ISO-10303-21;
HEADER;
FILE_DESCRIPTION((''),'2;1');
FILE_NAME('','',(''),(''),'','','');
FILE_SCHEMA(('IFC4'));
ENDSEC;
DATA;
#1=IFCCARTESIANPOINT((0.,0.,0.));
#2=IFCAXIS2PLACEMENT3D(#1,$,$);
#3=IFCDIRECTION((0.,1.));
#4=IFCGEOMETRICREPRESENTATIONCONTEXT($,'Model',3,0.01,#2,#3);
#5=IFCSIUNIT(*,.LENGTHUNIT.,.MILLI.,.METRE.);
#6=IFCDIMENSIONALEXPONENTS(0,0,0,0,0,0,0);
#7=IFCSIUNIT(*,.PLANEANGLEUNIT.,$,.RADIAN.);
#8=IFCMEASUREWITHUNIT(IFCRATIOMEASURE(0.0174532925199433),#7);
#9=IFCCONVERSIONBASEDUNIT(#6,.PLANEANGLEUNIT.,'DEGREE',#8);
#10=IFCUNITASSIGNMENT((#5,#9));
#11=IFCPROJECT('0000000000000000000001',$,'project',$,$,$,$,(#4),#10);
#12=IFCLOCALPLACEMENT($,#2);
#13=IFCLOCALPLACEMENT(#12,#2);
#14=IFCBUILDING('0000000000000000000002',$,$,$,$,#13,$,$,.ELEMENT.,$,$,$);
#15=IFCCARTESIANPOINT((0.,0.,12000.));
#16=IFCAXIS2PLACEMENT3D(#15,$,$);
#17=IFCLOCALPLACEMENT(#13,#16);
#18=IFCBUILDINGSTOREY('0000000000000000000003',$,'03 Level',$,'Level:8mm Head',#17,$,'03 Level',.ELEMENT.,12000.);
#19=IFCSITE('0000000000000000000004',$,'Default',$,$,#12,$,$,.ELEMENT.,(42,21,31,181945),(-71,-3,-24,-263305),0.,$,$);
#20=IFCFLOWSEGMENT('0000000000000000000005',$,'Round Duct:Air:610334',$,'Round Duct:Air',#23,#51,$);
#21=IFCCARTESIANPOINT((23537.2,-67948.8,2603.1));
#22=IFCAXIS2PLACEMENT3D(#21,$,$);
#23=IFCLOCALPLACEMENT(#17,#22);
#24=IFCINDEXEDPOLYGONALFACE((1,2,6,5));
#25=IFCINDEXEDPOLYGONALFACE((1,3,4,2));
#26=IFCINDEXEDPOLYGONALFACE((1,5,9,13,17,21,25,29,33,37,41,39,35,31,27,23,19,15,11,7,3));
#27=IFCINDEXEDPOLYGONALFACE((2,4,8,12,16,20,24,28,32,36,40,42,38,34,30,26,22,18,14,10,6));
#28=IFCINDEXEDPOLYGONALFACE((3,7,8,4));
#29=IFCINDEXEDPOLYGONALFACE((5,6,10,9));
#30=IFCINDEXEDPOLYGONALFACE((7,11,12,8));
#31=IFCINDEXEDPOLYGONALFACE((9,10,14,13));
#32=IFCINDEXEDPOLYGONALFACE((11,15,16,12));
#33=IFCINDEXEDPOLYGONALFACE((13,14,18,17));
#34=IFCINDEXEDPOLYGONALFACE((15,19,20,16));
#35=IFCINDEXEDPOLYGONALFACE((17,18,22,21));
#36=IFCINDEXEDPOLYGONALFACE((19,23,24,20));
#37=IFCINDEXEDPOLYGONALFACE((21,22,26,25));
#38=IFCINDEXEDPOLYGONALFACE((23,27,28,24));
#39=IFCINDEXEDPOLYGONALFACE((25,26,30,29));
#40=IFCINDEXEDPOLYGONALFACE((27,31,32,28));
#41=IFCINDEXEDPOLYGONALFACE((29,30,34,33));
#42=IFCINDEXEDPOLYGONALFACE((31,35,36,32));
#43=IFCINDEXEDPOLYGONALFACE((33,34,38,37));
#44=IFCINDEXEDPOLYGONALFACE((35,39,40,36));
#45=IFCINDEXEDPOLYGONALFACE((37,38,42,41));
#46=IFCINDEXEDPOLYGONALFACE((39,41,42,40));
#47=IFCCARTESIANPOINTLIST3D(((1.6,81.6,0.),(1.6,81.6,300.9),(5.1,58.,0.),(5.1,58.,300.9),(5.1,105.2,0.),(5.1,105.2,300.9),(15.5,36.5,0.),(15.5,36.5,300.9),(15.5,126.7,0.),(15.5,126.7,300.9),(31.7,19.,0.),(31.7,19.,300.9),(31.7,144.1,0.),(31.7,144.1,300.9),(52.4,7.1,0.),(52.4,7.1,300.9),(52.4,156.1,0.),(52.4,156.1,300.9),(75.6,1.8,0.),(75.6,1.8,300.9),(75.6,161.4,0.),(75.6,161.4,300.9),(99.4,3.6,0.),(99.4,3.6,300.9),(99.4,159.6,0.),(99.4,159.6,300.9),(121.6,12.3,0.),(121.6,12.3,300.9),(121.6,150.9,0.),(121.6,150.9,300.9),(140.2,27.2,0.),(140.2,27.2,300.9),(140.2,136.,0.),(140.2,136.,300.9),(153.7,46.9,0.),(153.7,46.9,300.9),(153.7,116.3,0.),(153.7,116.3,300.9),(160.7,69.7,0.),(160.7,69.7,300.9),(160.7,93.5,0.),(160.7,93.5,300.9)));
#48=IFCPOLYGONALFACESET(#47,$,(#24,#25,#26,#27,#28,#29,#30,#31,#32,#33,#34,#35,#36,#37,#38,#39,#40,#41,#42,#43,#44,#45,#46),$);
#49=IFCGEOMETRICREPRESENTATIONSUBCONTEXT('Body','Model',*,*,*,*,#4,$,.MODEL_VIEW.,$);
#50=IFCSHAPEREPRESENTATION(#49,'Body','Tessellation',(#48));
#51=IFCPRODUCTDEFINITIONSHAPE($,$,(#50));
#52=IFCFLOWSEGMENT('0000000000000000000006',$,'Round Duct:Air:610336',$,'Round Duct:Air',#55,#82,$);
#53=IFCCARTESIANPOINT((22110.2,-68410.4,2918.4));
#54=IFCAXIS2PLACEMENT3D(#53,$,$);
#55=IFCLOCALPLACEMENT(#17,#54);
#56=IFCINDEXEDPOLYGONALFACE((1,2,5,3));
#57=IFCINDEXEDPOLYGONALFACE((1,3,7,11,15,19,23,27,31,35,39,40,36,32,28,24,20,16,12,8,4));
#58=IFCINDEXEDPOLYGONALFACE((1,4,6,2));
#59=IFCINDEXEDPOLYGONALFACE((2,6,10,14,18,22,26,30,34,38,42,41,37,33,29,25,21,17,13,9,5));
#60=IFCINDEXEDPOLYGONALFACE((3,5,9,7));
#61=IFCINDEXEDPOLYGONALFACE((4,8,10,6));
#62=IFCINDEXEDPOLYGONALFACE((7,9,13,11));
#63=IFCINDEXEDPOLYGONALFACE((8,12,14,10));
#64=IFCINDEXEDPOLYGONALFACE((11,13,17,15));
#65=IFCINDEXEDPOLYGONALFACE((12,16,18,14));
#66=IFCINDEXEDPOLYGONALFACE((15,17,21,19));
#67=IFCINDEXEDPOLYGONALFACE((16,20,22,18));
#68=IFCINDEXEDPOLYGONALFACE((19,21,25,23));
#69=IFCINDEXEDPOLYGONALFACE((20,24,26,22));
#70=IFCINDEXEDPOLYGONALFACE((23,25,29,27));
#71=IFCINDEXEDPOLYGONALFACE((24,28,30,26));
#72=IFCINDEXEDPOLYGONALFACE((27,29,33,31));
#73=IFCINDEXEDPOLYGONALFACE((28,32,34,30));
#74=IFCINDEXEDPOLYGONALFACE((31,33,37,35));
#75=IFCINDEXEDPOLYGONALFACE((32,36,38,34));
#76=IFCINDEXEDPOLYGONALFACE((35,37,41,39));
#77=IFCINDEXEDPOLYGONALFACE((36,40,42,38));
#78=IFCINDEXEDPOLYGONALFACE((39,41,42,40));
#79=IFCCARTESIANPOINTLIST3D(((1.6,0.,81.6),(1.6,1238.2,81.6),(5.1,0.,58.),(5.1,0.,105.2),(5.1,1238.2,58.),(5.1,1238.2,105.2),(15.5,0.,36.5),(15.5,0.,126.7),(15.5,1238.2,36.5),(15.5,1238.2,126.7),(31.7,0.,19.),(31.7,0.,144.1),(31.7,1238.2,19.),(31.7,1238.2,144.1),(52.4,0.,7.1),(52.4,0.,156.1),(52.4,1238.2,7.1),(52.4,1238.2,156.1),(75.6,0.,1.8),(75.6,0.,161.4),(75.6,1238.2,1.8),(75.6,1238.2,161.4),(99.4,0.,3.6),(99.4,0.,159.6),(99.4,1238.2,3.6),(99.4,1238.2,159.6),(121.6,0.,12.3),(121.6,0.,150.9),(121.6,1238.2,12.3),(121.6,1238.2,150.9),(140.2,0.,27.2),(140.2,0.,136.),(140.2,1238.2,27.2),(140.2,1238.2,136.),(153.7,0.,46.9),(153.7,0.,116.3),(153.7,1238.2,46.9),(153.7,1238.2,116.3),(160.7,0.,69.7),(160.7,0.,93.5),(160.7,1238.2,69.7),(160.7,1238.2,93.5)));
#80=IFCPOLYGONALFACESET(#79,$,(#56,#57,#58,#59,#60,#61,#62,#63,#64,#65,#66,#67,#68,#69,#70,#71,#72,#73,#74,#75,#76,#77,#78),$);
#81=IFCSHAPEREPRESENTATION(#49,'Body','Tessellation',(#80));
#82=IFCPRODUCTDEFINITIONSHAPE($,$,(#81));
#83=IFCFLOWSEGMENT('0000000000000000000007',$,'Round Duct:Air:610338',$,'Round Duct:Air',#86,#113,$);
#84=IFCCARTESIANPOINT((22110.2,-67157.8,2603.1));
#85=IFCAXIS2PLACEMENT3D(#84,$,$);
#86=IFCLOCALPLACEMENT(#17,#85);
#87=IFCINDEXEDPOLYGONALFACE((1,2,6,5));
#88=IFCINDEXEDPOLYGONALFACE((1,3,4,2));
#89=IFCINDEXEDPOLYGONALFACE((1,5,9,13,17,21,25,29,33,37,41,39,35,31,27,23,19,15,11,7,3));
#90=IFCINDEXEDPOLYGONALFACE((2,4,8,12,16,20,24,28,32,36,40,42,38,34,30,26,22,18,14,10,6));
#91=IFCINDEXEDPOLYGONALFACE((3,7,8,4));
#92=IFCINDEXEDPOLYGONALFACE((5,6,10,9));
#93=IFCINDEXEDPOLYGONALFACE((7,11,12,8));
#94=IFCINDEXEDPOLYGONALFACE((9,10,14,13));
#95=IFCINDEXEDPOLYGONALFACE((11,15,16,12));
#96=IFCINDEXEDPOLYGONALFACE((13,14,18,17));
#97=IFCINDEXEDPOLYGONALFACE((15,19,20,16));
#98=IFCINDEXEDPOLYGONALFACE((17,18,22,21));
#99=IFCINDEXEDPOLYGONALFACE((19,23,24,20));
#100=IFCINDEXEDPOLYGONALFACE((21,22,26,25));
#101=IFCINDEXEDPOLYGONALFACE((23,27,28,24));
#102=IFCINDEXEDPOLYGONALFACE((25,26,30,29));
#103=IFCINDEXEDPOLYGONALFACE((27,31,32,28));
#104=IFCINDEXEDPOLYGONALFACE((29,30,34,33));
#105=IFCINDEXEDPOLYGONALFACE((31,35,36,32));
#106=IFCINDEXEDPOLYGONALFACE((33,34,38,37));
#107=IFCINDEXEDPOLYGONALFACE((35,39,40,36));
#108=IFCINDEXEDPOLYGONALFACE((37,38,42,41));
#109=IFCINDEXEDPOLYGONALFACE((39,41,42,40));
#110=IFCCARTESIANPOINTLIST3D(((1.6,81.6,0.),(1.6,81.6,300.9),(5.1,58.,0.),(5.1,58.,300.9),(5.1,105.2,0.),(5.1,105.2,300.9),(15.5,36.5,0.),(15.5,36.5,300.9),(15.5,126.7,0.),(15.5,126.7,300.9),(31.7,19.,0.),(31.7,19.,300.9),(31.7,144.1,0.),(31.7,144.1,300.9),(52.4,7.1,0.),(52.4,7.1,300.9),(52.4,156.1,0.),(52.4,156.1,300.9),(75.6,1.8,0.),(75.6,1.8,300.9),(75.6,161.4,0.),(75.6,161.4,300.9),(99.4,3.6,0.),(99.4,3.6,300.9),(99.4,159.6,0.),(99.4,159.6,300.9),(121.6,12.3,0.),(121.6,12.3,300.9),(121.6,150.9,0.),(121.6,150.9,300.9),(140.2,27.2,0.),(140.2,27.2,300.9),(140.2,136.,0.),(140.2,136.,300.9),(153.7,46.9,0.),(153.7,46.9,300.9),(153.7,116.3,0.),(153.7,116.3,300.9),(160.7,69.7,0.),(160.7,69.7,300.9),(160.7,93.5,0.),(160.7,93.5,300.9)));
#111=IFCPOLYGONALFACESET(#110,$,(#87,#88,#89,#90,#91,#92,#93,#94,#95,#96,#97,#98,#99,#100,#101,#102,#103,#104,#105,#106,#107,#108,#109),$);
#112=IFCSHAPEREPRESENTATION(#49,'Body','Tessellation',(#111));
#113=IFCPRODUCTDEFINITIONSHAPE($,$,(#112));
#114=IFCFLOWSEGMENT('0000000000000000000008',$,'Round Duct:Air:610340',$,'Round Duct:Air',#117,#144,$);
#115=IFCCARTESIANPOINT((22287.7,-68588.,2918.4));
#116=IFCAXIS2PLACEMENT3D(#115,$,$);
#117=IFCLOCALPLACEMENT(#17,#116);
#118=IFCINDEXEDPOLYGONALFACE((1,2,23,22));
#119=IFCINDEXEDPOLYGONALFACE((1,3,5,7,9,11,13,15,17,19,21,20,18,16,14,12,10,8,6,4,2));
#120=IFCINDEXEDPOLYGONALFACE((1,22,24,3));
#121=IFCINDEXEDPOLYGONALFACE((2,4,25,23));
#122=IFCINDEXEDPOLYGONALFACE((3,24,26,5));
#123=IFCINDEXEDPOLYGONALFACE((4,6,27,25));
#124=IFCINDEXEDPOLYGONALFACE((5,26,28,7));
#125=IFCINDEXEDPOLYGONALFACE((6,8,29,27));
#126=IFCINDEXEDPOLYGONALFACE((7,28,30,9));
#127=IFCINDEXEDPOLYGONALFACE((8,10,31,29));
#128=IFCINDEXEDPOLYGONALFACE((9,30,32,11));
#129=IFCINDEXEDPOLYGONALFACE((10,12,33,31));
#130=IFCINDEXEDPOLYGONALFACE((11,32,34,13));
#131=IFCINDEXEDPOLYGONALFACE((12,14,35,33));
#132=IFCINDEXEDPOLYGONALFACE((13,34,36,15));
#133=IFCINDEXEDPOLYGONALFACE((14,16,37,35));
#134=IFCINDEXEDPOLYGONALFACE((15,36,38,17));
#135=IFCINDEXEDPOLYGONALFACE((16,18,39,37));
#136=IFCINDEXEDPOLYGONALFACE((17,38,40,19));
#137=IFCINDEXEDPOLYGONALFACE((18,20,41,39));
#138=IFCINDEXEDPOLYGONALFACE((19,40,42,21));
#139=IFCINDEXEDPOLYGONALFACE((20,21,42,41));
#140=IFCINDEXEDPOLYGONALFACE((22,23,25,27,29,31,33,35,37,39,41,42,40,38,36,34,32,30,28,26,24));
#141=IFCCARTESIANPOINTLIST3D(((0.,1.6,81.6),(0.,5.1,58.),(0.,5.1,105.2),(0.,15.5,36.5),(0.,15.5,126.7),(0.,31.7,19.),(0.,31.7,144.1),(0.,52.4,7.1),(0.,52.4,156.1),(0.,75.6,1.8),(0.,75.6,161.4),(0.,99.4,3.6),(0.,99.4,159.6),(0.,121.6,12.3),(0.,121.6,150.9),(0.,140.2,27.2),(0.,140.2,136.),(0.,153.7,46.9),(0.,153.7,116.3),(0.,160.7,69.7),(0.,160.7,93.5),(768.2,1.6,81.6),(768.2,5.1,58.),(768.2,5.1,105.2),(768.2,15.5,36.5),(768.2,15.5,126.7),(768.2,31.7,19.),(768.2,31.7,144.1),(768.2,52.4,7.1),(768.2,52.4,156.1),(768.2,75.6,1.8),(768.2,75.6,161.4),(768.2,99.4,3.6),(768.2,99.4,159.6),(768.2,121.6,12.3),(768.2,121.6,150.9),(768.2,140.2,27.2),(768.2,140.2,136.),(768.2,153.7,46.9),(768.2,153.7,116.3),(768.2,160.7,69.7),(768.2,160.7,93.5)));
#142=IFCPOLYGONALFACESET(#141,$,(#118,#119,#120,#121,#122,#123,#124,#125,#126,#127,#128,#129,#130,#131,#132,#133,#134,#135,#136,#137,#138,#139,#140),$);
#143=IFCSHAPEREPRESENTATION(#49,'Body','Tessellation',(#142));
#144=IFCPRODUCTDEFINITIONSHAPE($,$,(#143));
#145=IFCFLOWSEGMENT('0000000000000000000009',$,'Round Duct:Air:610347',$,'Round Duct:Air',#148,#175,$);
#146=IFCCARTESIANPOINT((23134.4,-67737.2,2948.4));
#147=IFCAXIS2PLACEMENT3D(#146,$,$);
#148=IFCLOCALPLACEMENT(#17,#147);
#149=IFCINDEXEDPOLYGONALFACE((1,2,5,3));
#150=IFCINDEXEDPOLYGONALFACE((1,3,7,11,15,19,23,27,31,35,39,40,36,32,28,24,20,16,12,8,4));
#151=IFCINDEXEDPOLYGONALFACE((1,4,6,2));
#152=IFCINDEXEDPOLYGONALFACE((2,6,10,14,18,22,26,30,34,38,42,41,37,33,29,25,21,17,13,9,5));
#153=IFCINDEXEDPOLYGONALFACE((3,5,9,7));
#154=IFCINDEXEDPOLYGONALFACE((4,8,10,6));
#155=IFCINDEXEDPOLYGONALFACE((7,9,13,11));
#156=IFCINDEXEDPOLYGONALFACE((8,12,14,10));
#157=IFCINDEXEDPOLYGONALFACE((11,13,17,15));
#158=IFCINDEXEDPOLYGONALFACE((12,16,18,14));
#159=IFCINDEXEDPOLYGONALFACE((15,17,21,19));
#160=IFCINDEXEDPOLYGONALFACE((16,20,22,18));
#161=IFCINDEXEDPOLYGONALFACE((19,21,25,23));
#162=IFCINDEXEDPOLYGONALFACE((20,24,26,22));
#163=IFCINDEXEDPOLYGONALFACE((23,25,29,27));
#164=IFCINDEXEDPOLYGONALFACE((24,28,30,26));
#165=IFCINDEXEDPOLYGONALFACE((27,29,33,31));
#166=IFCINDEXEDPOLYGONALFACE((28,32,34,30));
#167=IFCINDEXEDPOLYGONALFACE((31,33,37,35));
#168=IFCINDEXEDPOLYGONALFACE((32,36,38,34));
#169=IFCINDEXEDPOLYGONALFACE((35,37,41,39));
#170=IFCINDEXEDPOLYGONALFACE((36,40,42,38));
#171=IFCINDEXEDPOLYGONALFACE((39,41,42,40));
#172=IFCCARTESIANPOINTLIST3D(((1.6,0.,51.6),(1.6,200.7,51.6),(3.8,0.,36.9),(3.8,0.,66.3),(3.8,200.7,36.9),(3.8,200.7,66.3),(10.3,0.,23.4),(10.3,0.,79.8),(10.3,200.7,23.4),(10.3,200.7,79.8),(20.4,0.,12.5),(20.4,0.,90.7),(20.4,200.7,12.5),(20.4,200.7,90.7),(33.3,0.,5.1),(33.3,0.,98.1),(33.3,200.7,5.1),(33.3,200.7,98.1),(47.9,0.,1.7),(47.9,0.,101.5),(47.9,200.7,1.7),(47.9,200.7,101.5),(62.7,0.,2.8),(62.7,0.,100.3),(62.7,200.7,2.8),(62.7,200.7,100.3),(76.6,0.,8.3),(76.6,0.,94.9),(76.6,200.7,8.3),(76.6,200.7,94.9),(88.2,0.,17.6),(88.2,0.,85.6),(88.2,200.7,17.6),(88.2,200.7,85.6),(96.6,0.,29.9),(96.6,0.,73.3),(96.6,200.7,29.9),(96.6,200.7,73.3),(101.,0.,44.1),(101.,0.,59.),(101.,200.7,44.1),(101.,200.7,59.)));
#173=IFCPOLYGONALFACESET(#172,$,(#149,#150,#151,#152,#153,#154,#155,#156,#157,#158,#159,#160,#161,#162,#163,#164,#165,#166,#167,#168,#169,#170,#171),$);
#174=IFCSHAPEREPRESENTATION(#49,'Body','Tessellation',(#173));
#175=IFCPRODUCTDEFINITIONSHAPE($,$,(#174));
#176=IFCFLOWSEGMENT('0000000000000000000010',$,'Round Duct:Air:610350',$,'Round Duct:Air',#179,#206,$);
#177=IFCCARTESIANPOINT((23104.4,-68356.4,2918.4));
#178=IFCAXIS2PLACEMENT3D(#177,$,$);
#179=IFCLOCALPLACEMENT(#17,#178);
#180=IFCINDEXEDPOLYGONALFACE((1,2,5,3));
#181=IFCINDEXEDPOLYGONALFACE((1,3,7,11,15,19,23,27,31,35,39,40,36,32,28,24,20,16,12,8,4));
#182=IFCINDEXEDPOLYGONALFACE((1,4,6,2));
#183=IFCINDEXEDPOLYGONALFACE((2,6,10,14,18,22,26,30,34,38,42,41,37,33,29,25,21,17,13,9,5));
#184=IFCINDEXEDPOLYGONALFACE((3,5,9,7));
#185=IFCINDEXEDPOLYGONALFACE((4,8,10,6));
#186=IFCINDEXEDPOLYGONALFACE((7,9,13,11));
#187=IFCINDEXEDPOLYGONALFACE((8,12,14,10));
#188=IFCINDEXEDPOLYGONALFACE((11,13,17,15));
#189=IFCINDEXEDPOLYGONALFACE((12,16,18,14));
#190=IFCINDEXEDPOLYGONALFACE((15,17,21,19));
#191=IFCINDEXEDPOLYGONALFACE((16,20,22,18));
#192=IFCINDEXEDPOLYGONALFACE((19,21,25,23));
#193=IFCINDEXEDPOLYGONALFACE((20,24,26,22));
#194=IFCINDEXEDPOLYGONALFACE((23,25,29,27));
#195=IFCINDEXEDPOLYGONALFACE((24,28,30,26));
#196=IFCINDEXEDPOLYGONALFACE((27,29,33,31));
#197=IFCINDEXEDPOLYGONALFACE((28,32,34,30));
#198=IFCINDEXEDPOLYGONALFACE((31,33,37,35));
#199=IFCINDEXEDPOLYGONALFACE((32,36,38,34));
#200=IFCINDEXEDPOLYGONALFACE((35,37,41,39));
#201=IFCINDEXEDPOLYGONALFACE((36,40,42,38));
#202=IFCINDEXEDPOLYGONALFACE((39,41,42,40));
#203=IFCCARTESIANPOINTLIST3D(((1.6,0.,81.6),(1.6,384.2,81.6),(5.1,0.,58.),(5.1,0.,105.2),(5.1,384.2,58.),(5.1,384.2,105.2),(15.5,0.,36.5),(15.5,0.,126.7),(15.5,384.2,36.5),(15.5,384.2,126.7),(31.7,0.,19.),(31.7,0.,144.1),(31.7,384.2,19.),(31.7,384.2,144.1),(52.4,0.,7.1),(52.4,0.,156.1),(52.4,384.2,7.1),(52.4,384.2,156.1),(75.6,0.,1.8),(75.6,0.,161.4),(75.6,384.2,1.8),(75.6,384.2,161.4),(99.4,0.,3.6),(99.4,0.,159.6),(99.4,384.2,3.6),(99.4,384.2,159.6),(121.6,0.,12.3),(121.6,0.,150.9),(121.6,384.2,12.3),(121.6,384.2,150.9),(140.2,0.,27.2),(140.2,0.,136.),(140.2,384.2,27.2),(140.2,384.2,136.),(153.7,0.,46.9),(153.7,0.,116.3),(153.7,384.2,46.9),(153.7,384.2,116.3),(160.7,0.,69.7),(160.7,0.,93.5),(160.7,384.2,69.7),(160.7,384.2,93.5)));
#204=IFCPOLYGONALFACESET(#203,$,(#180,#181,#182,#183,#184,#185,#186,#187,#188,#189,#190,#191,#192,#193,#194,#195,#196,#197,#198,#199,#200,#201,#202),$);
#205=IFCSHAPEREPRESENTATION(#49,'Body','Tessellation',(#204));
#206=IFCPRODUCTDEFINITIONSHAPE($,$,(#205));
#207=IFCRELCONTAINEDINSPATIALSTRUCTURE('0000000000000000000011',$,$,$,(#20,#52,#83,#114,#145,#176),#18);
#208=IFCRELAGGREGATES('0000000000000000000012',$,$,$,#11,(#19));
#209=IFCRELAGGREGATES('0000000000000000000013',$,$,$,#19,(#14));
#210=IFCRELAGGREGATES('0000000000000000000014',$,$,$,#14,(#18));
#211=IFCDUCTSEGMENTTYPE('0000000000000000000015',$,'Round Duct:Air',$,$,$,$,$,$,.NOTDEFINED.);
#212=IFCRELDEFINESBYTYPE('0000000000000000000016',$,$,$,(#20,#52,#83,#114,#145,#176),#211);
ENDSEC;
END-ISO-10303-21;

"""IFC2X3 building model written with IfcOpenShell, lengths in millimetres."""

from ifc_helpers import new_model, entity, si_unit, converted_unit, direction, frame, frame_2d, origin, origin_2d_with_axis, place, context, subcontext, project, spatial, circle, extrude, type_object, element, save


model = new_model("IFC2X3")

# Units and contexts
model_context = context("Model", 3, precision=0.01, world=origin(), true_north=direction((0.0, 1.0)))
body_context = subcontext(model_context, "Body", "Model", "MODEL_VIEW")
ifc_project = project(units=[si_unit("LENGTHUNIT", "METRE", prefix="MILLI"), converted_unit("PLANEANGLEUNIT", "DEGREE", entity("IfcRatioMeasure", 0.0174532925199433), si_unit("PLANEANGLEUNIT", "RADIAN"), dimensions=[0, 0, 0, 0, 0, 0, 0])], contexts=[model_context])

# Site, building, storey
site_placement = place(None, origin())
site = spatial("IfcSite", under=ifc_project, at=site_placement, Name="Default", CompositionType="ELEMENT", RefLatitude=(42, 21, 31, 181945), RefLongitude=(-71, -3, -24, -263305), RefElevation=0.0)
building_placement = place(site_placement, origin())
building = spatial("IfcBuilding", under=site, at=building_placement, CompositionType="ELEMENT")
storey_placement = place(building_placement, frame((0.0, 0.0, 12000.0)))
storey = spatial("IfcBuildingStorey", under=building, at=storey_placement, Name="03 Level", ObjectType="Level:8mm Head", LongName="03 Level", CompositionType="ELEMENT", Elevation=12000.0)

# Flow segments
duct_segment_type_1 = type_object("IfcDuctSegmentType", Name="Round Duct:Air", PredefinedType="NOTDEFINED")
flow_segment_1_placement = place(storey_placement, frame((23537.2, -67948.8, 2603.1)))
element("IfcFlowSegment", 1, at=flow_segment_1_placement, inside=storey, type_object=duct_segment_type_1, Name="Round Duct:Air:610334", ObjectType="Round Duct:Air", context=body_context, shape_type="SweptSolid", body=[
    extrude(circle(Radius=80.0, at=origin_2d_with_axis()), frame((81.6, 81.6, 0.0), z_axis=(0.0, 0.0, 1.0), x_axis=(-1.0, 0.0, 0.0)), (0.0, 0.0, 1.0), 300.9),
])
flow_segment_2_placement = place(storey_placement, frame((22110.2, -68410.4, 2918.4)))
element("IfcFlowSegment", 2, at=flow_segment_2_placement, inside=storey, type_object=duct_segment_type_1, Name="Round Duct:Air:610336", ObjectType="Round Duct:Air", context=body_context, shape_type="SweptSolid", body=[
    extrude(circle(Radius=80.0, at=frame_2d((0.0, 0.0), x_axis=(1.0, 0.0))), frame((81.6, 0.0, 81.6), z_axis=(0.0, 1.0, 0.0), x_axis=(-1.0, 0.0, 0.0)), (0.0, 0.0, 1.0), 1238.2),
])
flow_segment_3_placement = place(storey_placement, frame((22110.2, -67157.8, 2603.1)))
element("IfcFlowSegment", 3, at=flow_segment_3_placement, inside=storey, type_object=duct_segment_type_1, Name="Round Duct:Air:610338", ObjectType="Round Duct:Air", context=body_context, shape_type="SweptSolid", body=[
    extrude(circle(Radius=80.0, at=origin_2d_with_axis()), frame((81.6, 81.6, 0.0), z_axis=(0.0, 0.0, 1.0), x_axis=(-1.0, 0.0, 0.0)), (0.0, 0.0, 1.0), 300.9),
])
flow_segment_4_placement = place(storey_placement, frame((22287.7, -68588.0, 2918.4)))
element("IfcFlowSegment", 4, at=flow_segment_4_placement, inside=storey, type_object=duct_segment_type_1, Name="Round Duct:Air:610340", ObjectType="Round Duct:Air", context=body_context, shape_type="SweptSolid", body=[
    extrude(circle(Radius=80.0, at=origin_2d_with_axis()), frame((0.0, 81.6, 81.6), z_axis=(1.0, 0.0, 0.0), x_axis=(0.0, -1.0, 0.0)), (0.0, 0.0, 1.0), 768.2),
])
flow_segment_5_placement = place(storey_placement, frame((23134.4, -67737.2, 2948.4)))
element("IfcFlowSegment", 5, at=flow_segment_5_placement, inside=storey, type_object=duct_segment_type_1, Name="Round Duct:Air:610347", ObjectType="Round Duct:Air", context=body_context, shape_type="SweptSolid", body=[
    extrude(circle(Radius=50.0, at=frame_2d((0.0, 0.0), x_axis=(1.0, 0.0))), frame((51.6, 0.0, 51.6), z_axis=(0.0, 1.0, 0.0), x_axis=(-1.0, 0.0, 0.0)), (0.0, 0.0, 1.0), 200.7),
])
flow_segment_6_placement = place(storey_placement, frame((23104.4, -68356.4, 2918.4)))
element("IfcFlowSegment", 6, at=flow_segment_6_placement, inside=storey, type_object=duct_segment_type_1, Name="Round Duct:Air:610350", ObjectType="Round Duct:Air", context=body_context, shape_type="SweptSolid", body=[
    extrude(circle(Radius=80.0, at=frame_2d((0.0, 0.0), x_axis=(1.0, 0.0))), frame((81.6, 0.0, 81.6), z_axis=(0.0, 1.0, 0.0), x_axis=(-1.0, 0.0, 0.0)), (0.0, 0.0, 1.0), 384.2),
])

save(model, "model.ifc")
